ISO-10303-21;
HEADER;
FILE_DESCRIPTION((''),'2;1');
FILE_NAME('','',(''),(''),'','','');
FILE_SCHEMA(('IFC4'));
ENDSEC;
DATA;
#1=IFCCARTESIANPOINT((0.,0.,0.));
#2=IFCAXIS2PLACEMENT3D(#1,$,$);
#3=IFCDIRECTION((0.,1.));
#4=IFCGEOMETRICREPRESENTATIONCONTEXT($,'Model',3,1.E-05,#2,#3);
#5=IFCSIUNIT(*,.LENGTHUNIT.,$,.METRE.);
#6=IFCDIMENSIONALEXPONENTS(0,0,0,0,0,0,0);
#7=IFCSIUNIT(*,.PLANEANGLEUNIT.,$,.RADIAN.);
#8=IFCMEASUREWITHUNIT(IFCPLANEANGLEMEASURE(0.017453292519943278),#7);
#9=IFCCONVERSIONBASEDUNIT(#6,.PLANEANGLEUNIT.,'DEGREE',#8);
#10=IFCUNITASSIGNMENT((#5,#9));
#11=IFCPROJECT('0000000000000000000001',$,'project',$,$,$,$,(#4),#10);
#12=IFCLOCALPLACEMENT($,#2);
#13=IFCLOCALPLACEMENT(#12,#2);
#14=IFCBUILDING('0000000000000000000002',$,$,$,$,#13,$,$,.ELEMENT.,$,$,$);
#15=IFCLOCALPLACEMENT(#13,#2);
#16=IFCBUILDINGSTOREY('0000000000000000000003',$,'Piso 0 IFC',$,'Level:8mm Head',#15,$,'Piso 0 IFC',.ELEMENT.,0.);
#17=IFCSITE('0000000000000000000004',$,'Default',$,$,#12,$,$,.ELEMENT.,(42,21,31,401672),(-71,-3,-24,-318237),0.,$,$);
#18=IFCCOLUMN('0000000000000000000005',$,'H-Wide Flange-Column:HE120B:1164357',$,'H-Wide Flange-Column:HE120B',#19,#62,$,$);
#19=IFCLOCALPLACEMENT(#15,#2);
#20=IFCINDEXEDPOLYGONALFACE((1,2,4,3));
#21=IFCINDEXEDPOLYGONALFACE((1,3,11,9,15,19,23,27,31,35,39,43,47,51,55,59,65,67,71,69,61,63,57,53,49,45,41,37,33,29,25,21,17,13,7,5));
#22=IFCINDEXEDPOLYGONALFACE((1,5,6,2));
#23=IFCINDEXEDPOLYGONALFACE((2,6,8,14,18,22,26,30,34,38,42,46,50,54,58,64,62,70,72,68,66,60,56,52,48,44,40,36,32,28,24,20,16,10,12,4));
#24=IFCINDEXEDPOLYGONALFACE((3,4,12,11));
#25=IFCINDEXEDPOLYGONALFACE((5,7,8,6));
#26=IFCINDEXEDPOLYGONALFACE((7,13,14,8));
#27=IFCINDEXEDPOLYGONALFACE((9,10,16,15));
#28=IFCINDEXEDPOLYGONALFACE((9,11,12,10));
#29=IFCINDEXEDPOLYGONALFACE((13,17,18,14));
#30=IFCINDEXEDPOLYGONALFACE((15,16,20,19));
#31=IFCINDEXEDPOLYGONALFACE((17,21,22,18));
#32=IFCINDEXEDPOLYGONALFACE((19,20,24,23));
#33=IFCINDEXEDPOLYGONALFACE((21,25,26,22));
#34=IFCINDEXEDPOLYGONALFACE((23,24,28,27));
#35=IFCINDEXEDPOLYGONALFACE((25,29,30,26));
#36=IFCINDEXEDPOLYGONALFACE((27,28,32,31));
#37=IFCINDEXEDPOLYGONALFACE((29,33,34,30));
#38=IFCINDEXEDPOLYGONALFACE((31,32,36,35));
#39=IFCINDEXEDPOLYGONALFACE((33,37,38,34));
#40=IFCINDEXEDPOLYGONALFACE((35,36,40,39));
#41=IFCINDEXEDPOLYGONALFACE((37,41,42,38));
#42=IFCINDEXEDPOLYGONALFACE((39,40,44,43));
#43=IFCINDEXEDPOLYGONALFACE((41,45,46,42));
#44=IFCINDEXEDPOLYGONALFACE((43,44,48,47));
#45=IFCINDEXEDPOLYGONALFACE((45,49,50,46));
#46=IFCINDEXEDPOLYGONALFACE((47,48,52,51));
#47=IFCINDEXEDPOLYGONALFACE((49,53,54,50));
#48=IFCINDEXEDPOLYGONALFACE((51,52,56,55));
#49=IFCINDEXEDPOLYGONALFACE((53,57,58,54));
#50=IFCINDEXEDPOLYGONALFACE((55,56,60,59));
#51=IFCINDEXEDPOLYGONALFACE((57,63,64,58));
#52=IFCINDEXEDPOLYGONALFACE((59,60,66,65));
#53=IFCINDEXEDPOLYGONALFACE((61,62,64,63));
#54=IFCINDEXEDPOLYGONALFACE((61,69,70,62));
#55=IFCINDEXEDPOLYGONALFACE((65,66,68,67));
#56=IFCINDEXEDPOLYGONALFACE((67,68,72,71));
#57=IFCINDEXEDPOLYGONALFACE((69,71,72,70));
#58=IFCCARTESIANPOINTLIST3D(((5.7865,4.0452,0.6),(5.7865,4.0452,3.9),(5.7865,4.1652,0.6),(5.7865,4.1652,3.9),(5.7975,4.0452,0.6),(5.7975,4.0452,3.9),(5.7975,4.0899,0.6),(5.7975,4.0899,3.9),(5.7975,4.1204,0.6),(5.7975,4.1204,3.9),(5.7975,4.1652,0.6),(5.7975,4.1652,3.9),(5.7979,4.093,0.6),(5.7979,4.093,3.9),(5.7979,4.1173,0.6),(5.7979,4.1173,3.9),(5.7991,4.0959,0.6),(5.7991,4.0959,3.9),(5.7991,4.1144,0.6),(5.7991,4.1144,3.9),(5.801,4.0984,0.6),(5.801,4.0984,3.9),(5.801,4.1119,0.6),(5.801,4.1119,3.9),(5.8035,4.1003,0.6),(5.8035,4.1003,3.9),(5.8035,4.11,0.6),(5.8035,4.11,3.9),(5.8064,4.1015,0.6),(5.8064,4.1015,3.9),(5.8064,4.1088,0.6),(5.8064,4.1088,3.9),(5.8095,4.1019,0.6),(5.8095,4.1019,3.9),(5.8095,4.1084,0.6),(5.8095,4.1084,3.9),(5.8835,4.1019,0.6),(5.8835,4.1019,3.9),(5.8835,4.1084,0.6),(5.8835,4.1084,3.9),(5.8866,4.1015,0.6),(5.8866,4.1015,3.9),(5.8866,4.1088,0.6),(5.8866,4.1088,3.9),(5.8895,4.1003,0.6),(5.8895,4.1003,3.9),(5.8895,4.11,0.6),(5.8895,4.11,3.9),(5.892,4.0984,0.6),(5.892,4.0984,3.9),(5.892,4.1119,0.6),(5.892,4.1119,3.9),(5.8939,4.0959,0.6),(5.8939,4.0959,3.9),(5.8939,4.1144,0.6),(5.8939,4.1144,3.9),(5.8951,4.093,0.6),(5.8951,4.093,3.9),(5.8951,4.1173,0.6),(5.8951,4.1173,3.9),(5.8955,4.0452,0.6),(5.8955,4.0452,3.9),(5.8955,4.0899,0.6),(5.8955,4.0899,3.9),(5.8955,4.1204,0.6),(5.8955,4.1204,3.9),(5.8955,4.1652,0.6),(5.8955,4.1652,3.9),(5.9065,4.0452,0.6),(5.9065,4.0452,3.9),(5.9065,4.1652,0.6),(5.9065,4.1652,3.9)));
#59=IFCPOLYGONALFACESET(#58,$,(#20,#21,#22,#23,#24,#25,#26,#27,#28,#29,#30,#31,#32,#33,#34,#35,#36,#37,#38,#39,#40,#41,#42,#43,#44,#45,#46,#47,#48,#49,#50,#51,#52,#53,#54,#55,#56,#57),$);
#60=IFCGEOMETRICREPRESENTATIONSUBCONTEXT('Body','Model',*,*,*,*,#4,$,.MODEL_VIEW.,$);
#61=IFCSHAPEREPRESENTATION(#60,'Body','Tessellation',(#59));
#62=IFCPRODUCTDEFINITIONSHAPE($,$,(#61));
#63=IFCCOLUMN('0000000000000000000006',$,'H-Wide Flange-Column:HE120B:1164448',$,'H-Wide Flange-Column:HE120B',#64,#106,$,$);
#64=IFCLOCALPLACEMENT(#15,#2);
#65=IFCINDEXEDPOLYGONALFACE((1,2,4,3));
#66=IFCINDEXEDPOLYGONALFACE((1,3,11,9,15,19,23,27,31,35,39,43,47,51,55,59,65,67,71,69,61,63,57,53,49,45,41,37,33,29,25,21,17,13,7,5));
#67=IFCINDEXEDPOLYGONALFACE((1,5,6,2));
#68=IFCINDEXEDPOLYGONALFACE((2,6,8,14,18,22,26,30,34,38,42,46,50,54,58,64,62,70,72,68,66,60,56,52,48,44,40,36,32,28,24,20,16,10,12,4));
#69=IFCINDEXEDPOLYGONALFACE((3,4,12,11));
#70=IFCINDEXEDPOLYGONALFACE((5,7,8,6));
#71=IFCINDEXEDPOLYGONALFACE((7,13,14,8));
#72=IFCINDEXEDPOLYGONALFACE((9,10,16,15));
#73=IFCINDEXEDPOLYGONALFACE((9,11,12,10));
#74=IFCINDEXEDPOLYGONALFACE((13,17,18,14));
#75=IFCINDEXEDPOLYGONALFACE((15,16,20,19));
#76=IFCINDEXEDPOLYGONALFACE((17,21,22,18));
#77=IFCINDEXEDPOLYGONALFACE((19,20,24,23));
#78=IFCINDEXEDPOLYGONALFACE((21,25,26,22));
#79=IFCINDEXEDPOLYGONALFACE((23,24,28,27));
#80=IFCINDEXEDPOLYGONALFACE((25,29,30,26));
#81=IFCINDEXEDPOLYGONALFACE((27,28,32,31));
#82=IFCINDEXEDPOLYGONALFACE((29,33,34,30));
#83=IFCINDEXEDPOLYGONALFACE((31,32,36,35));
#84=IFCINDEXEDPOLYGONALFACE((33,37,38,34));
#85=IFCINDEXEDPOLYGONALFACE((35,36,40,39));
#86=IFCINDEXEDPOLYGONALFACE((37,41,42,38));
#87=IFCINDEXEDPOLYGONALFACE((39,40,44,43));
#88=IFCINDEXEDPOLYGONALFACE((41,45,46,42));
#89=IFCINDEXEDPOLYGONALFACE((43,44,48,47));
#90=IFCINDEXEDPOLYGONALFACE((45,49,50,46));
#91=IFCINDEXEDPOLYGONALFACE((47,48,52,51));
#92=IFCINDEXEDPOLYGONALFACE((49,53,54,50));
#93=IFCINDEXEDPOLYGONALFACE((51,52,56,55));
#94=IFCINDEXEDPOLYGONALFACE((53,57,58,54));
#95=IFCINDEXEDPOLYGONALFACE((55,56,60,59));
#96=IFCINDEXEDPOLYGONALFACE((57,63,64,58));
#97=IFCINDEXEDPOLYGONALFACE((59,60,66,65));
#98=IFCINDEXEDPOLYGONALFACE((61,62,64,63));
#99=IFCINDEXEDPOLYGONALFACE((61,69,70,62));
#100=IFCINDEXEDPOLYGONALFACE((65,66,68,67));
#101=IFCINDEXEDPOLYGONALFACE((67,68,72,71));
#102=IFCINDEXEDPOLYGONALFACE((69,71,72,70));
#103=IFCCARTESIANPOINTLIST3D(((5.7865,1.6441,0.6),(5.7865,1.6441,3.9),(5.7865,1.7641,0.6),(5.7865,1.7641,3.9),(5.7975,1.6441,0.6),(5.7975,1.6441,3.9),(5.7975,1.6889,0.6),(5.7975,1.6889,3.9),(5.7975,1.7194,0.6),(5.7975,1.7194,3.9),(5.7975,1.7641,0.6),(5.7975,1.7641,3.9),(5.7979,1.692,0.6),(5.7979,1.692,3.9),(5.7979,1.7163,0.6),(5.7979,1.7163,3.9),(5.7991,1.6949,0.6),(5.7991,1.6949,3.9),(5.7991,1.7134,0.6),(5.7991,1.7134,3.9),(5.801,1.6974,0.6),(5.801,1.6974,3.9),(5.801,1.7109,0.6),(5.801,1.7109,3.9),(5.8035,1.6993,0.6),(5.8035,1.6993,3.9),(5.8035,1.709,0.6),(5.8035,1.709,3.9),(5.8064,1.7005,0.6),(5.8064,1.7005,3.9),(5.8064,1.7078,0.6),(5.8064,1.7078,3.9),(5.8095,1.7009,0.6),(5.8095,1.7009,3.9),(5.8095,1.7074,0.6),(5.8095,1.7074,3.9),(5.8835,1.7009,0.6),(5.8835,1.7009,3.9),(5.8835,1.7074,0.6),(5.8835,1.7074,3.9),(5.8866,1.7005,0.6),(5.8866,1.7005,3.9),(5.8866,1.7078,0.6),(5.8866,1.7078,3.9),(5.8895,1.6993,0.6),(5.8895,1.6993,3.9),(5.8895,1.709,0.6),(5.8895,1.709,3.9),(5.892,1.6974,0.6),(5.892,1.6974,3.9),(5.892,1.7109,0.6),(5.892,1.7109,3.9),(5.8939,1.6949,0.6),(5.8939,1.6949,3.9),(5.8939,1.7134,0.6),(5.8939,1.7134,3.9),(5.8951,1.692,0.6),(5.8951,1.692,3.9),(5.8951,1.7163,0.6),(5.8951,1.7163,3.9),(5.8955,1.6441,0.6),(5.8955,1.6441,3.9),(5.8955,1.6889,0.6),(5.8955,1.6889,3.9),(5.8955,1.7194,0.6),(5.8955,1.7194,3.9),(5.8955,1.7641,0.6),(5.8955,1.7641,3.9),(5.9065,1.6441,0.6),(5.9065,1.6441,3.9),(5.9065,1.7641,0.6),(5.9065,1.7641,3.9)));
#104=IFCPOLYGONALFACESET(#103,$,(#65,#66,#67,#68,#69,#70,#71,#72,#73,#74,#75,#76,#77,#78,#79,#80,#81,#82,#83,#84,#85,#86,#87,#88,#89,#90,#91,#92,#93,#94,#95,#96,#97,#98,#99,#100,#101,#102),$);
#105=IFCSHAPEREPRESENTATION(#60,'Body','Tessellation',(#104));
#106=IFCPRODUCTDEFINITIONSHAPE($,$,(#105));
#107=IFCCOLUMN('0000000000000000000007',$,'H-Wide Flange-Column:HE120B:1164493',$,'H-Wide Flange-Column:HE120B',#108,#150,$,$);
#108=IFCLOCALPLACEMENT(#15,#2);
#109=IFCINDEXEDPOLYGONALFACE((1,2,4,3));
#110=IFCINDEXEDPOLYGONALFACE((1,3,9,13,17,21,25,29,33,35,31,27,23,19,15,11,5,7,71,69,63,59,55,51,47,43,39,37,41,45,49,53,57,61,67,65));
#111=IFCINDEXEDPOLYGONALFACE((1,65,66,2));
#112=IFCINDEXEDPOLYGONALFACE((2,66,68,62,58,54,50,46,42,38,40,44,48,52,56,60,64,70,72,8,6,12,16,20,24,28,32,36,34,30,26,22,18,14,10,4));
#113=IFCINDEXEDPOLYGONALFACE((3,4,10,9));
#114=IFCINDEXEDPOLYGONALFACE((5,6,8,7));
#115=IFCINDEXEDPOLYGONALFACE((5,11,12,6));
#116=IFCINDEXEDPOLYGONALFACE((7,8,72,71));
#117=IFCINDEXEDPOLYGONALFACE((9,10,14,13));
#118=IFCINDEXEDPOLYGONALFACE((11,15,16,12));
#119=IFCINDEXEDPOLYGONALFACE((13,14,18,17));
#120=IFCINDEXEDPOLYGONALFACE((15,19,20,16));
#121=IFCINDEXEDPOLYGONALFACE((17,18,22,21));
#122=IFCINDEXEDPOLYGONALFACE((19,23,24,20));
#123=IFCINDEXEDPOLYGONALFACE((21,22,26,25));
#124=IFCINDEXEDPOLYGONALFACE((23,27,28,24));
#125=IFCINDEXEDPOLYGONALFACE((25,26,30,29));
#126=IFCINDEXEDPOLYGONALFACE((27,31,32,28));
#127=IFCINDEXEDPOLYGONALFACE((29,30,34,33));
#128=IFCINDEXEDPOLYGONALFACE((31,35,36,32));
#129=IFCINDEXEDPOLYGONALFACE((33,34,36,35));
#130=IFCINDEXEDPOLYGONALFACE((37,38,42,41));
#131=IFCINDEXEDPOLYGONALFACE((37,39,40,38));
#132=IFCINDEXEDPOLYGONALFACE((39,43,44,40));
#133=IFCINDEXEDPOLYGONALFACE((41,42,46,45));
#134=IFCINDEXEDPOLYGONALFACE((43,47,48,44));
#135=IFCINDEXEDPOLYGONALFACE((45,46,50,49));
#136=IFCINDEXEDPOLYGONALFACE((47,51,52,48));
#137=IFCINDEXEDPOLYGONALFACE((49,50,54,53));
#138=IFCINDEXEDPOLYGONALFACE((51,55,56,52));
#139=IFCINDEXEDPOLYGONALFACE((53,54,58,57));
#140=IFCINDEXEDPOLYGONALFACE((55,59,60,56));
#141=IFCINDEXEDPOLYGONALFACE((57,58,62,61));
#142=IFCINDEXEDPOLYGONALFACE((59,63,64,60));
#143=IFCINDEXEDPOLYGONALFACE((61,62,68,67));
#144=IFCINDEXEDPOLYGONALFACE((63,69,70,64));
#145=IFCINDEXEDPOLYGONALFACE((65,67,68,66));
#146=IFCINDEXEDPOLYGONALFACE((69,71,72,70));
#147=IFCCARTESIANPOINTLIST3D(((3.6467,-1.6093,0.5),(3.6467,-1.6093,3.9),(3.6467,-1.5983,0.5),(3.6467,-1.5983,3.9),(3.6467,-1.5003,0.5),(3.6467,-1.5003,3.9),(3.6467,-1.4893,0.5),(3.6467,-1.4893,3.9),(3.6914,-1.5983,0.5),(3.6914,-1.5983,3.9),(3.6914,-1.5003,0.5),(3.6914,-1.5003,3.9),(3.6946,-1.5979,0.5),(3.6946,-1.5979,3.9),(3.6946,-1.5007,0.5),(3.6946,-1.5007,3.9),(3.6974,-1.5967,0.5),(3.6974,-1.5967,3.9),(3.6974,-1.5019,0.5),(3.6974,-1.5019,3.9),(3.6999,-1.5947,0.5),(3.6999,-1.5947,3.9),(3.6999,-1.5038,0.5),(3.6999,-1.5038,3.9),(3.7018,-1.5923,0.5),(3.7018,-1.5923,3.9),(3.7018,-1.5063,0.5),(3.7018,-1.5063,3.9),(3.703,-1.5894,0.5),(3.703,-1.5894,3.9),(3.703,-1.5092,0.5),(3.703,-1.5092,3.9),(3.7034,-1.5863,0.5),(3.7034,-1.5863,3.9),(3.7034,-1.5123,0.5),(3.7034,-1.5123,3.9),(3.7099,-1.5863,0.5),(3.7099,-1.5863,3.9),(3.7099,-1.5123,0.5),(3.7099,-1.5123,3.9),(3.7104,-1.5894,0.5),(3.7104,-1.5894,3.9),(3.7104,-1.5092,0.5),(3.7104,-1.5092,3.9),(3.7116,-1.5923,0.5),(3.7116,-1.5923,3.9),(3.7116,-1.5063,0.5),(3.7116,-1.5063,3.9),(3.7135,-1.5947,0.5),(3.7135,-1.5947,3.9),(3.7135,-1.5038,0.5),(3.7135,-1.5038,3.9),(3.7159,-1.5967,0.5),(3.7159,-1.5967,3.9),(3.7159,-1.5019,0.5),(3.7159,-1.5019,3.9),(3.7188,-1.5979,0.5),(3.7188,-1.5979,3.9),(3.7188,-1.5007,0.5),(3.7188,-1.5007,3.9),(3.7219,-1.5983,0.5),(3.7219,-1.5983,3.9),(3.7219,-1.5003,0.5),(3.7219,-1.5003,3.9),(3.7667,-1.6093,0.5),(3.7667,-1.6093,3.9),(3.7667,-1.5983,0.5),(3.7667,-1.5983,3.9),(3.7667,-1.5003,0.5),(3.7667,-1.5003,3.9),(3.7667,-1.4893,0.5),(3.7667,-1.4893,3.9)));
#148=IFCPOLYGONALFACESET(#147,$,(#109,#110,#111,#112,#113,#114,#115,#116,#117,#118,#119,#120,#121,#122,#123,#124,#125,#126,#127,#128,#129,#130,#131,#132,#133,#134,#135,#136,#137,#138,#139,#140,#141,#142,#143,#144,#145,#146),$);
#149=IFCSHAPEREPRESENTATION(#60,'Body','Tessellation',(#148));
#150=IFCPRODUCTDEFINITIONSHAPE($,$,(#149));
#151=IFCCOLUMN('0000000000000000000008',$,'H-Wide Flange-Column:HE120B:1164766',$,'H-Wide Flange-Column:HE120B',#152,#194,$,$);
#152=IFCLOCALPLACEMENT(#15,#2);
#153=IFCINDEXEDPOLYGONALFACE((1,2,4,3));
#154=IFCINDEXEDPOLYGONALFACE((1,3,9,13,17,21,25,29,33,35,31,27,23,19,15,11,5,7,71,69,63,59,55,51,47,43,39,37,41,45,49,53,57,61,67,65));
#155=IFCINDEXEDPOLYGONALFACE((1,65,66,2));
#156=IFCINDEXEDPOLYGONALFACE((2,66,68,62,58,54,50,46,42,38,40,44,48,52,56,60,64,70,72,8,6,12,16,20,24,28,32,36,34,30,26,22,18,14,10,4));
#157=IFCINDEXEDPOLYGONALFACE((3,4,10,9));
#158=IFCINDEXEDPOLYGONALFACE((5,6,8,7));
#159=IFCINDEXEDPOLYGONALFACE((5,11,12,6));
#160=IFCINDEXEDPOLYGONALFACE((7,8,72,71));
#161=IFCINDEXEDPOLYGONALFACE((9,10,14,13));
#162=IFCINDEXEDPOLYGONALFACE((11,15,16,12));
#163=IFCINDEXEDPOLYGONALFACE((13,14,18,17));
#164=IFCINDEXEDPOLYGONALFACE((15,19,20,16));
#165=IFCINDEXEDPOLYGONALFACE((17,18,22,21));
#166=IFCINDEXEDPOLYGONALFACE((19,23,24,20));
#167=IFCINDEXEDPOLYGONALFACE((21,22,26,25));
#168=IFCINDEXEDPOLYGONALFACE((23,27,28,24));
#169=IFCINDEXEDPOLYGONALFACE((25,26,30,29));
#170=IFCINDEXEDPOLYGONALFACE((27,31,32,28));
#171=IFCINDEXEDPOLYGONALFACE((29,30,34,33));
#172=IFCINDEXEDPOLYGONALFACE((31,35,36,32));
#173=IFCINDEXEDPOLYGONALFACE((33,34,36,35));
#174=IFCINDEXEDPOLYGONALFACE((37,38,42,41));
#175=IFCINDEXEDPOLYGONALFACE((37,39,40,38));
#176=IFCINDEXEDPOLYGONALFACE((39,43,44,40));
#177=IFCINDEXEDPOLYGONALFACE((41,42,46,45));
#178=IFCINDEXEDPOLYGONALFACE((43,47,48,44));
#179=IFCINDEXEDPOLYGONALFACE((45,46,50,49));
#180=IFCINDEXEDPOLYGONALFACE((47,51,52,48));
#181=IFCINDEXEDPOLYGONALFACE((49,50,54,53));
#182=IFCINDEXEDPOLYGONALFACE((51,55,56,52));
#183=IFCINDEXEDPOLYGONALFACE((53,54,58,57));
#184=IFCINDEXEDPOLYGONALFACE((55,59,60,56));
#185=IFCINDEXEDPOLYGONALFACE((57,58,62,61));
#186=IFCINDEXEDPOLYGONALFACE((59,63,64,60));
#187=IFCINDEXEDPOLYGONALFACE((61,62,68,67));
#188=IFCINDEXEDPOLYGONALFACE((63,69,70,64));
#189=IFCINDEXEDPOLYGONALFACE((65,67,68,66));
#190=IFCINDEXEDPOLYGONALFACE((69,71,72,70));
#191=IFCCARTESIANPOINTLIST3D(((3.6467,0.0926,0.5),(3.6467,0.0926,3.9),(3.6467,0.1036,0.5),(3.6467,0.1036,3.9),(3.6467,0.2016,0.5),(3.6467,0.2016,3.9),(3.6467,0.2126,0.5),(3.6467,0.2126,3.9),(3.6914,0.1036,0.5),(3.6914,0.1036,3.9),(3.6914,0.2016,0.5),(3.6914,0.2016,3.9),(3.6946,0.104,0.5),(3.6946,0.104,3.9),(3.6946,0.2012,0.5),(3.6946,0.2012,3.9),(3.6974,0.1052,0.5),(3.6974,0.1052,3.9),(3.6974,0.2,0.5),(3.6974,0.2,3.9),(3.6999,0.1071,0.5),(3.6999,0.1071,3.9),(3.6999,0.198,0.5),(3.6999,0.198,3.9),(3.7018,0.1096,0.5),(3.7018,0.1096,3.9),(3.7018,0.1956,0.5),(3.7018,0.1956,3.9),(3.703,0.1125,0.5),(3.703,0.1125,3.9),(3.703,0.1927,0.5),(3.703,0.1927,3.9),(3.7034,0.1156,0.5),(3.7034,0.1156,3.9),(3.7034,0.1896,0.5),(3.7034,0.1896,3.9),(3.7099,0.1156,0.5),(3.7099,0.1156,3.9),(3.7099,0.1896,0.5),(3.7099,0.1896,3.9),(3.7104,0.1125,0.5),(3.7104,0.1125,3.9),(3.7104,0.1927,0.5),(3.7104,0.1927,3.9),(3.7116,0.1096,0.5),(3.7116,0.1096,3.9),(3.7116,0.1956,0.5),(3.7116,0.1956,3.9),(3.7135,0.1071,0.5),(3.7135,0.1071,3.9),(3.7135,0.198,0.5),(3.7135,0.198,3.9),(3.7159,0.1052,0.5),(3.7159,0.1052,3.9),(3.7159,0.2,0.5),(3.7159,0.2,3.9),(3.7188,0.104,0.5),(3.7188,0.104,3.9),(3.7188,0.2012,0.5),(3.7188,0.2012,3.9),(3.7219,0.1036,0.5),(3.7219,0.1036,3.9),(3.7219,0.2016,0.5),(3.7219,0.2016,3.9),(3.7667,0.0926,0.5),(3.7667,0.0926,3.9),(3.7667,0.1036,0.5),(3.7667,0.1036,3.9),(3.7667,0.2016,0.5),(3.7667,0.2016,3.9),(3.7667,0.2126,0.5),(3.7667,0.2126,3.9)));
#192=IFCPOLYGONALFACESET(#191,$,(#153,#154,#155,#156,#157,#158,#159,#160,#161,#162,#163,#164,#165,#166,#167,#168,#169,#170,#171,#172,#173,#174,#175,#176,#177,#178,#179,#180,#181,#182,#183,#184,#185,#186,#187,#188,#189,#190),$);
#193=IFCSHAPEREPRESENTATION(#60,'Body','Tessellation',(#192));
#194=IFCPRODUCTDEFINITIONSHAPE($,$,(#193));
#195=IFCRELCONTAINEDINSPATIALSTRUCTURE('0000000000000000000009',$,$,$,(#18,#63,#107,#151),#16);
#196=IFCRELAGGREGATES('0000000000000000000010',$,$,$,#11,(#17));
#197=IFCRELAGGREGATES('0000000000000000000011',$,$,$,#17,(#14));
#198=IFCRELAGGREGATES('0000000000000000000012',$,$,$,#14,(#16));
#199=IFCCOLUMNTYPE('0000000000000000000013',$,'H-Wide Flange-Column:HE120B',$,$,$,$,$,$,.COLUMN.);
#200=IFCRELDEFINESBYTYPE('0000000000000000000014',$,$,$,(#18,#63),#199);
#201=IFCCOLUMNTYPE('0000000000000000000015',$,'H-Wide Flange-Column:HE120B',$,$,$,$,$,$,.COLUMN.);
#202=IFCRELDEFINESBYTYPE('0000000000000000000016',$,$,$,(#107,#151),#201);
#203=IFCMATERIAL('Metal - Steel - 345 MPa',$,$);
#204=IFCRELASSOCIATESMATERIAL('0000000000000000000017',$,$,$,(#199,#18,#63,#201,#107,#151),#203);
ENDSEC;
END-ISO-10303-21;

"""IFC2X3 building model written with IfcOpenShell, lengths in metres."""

from ifc_helpers import new_model, entity, si_unit, converted_unit, direction, frame, frame_2d, origin, place, context, subcontext, project, spatial, i_section, extrude, source, transform, mapped, material, type_object, type_shapes, element, save


model = new_model("IFC2X3")

# Units and contexts
model_context = context("Model", 3, precision=1e-05, world=origin(), true_north=direction((0.0, 1.0)))
body_context = subcontext(model_context, "Body", "Model", "MODEL_VIEW")
ifc_project = project(units=[si_unit("LENGTHUNIT", "METRE"), converted_unit("PLANEANGLEUNIT", "DEGREE", entity("IfcPlaneAngleMeasure", 0.017453292519943278), si_unit("PLANEANGLEUNIT", "RADIAN"), dimensions=[0, 0, 0, 0, 0, 0, 0])], contexts=[model_context])

# Site, building, storey
site_placement = place(None, origin())
site = spatial("IfcSite", under=ifc_project, at=site_placement, Name="Default", CompositionType="ELEMENT", RefLatitude=(42, 21, 31, 401672), RefLongitude=(-71, -3, -24, -318237), RefElevation=0.0)
building_placement = place(site_placement, origin())
building = spatial("IfcBuilding", under=site, at=building_placement, CompositionType="ELEMENT")
storey_placement = place(building_placement, origin())
storey = spatial("IfcBuildingStorey", under=building, at=storey_placement, Name="Piso 0 IFC", ObjectType="Level:8mm Head", LongName="Piso 0 IFC", CompositionType="ELEMENT", Elevation=0.0)

# Columns
ifc_material_1 = material(Name="Metal - Steel - 345 MPa")
column_type_1 = type_object("IfcColumnType", Name="H-Wide Flange-Column:HE120B", PredefinedType="COLUMN", material=ifc_material_1)
shared_shape_1 = source(origin(), body_context, "Body", "SweptSolid", [
    extrude(i_section(OverallWidth=0.12, OverallDepth=0.12, WebThickness=0.0065, FlangeThickness=0.011, FilletRadius=0.012, at=frame_2d((0.0, 0.0), x_axis=(1.0, 0.0))), frame((0.0, 0.0, 0.6), z_axis=(0.0, 0.0, 1.0), x_axis=(-1.0, 0.0, 0.0)), (0.0, 0.0, 1.0), 3.3),
])
type_shapes(column_type_1, [shared_shape_1])
for number, where, z_axis, x_axis, name in (
    (1, (5.8465, 4.1052, 0.0), (0.0, 0.0, 1.0), (0.0, -1.0, 0.0), "H-Wide Flange-Column:HE120B:1164357"),
    (2, (5.8465, 1.7041, 0.0), (0.0, 0.0, 1.0), (0.0, -1.0, 0.0), "H-Wide Flange-Column:HE120B:1164448"),
):
    element("IfcColumn", number, at=place(storey_placement, frame(where, z_axis=z_axis, x_axis=x_axis)), inside=storey, type_object=column_type_1, material=ifc_material_1, Name=name, ObjectType="H-Wide Flange-Column:HE120B", context=body_context, shape_type="MappedRepresentation", body=[
        mapped(shared_shape_1, transform((0.0, 0.0, 0.0), scale=1.0)),
    ])
column_type_2 = type_object("IfcColumnType", Name="H-Wide Flange-Column:HE120B", PredefinedType="COLUMN", material=ifc_material_1)
shared_shape_2 = source(origin(), body_context, "Body", "SweptSolid", [
    extrude(i_section(OverallWidth=0.12, OverallDepth=0.12, WebThickness=0.0065, FlangeThickness=0.011, FilletRadius=0.012, at=frame_2d((0.0, 0.0), x_axis=(1.0, 0.0))), frame((0.0, 0.0, 0.5), z_axis=(0.0, 0.0, 1.0), x_axis=(-1.0, 0.0, 0.0)), (0.0, 0.0, 1.0), 3.4),
])
type_shapes(column_type_2, [shared_shape_2])
for number, where, name in (
    (3, (3.7067, -1.5493, 0.0), "H-Wide Flange-Column:HE120B:1164493"),
    (4, (3.7067, 0.1526, 0.0), "H-Wide Flange-Column:HE120B:1164766"),
):
    element("IfcColumn", number, at=place(storey_placement, frame(where)), inside=storey, type_object=column_type_2, material=ifc_material_1, Name=name, ObjectType="H-Wide Flange-Column:HE120B", context=body_context, shape_type="MappedRepresentation", body=[
        mapped(shared_shape_2, transform((0.0, 0.0, 0.0), scale=1.0)),
    ])

save(model, "model.ifc")
